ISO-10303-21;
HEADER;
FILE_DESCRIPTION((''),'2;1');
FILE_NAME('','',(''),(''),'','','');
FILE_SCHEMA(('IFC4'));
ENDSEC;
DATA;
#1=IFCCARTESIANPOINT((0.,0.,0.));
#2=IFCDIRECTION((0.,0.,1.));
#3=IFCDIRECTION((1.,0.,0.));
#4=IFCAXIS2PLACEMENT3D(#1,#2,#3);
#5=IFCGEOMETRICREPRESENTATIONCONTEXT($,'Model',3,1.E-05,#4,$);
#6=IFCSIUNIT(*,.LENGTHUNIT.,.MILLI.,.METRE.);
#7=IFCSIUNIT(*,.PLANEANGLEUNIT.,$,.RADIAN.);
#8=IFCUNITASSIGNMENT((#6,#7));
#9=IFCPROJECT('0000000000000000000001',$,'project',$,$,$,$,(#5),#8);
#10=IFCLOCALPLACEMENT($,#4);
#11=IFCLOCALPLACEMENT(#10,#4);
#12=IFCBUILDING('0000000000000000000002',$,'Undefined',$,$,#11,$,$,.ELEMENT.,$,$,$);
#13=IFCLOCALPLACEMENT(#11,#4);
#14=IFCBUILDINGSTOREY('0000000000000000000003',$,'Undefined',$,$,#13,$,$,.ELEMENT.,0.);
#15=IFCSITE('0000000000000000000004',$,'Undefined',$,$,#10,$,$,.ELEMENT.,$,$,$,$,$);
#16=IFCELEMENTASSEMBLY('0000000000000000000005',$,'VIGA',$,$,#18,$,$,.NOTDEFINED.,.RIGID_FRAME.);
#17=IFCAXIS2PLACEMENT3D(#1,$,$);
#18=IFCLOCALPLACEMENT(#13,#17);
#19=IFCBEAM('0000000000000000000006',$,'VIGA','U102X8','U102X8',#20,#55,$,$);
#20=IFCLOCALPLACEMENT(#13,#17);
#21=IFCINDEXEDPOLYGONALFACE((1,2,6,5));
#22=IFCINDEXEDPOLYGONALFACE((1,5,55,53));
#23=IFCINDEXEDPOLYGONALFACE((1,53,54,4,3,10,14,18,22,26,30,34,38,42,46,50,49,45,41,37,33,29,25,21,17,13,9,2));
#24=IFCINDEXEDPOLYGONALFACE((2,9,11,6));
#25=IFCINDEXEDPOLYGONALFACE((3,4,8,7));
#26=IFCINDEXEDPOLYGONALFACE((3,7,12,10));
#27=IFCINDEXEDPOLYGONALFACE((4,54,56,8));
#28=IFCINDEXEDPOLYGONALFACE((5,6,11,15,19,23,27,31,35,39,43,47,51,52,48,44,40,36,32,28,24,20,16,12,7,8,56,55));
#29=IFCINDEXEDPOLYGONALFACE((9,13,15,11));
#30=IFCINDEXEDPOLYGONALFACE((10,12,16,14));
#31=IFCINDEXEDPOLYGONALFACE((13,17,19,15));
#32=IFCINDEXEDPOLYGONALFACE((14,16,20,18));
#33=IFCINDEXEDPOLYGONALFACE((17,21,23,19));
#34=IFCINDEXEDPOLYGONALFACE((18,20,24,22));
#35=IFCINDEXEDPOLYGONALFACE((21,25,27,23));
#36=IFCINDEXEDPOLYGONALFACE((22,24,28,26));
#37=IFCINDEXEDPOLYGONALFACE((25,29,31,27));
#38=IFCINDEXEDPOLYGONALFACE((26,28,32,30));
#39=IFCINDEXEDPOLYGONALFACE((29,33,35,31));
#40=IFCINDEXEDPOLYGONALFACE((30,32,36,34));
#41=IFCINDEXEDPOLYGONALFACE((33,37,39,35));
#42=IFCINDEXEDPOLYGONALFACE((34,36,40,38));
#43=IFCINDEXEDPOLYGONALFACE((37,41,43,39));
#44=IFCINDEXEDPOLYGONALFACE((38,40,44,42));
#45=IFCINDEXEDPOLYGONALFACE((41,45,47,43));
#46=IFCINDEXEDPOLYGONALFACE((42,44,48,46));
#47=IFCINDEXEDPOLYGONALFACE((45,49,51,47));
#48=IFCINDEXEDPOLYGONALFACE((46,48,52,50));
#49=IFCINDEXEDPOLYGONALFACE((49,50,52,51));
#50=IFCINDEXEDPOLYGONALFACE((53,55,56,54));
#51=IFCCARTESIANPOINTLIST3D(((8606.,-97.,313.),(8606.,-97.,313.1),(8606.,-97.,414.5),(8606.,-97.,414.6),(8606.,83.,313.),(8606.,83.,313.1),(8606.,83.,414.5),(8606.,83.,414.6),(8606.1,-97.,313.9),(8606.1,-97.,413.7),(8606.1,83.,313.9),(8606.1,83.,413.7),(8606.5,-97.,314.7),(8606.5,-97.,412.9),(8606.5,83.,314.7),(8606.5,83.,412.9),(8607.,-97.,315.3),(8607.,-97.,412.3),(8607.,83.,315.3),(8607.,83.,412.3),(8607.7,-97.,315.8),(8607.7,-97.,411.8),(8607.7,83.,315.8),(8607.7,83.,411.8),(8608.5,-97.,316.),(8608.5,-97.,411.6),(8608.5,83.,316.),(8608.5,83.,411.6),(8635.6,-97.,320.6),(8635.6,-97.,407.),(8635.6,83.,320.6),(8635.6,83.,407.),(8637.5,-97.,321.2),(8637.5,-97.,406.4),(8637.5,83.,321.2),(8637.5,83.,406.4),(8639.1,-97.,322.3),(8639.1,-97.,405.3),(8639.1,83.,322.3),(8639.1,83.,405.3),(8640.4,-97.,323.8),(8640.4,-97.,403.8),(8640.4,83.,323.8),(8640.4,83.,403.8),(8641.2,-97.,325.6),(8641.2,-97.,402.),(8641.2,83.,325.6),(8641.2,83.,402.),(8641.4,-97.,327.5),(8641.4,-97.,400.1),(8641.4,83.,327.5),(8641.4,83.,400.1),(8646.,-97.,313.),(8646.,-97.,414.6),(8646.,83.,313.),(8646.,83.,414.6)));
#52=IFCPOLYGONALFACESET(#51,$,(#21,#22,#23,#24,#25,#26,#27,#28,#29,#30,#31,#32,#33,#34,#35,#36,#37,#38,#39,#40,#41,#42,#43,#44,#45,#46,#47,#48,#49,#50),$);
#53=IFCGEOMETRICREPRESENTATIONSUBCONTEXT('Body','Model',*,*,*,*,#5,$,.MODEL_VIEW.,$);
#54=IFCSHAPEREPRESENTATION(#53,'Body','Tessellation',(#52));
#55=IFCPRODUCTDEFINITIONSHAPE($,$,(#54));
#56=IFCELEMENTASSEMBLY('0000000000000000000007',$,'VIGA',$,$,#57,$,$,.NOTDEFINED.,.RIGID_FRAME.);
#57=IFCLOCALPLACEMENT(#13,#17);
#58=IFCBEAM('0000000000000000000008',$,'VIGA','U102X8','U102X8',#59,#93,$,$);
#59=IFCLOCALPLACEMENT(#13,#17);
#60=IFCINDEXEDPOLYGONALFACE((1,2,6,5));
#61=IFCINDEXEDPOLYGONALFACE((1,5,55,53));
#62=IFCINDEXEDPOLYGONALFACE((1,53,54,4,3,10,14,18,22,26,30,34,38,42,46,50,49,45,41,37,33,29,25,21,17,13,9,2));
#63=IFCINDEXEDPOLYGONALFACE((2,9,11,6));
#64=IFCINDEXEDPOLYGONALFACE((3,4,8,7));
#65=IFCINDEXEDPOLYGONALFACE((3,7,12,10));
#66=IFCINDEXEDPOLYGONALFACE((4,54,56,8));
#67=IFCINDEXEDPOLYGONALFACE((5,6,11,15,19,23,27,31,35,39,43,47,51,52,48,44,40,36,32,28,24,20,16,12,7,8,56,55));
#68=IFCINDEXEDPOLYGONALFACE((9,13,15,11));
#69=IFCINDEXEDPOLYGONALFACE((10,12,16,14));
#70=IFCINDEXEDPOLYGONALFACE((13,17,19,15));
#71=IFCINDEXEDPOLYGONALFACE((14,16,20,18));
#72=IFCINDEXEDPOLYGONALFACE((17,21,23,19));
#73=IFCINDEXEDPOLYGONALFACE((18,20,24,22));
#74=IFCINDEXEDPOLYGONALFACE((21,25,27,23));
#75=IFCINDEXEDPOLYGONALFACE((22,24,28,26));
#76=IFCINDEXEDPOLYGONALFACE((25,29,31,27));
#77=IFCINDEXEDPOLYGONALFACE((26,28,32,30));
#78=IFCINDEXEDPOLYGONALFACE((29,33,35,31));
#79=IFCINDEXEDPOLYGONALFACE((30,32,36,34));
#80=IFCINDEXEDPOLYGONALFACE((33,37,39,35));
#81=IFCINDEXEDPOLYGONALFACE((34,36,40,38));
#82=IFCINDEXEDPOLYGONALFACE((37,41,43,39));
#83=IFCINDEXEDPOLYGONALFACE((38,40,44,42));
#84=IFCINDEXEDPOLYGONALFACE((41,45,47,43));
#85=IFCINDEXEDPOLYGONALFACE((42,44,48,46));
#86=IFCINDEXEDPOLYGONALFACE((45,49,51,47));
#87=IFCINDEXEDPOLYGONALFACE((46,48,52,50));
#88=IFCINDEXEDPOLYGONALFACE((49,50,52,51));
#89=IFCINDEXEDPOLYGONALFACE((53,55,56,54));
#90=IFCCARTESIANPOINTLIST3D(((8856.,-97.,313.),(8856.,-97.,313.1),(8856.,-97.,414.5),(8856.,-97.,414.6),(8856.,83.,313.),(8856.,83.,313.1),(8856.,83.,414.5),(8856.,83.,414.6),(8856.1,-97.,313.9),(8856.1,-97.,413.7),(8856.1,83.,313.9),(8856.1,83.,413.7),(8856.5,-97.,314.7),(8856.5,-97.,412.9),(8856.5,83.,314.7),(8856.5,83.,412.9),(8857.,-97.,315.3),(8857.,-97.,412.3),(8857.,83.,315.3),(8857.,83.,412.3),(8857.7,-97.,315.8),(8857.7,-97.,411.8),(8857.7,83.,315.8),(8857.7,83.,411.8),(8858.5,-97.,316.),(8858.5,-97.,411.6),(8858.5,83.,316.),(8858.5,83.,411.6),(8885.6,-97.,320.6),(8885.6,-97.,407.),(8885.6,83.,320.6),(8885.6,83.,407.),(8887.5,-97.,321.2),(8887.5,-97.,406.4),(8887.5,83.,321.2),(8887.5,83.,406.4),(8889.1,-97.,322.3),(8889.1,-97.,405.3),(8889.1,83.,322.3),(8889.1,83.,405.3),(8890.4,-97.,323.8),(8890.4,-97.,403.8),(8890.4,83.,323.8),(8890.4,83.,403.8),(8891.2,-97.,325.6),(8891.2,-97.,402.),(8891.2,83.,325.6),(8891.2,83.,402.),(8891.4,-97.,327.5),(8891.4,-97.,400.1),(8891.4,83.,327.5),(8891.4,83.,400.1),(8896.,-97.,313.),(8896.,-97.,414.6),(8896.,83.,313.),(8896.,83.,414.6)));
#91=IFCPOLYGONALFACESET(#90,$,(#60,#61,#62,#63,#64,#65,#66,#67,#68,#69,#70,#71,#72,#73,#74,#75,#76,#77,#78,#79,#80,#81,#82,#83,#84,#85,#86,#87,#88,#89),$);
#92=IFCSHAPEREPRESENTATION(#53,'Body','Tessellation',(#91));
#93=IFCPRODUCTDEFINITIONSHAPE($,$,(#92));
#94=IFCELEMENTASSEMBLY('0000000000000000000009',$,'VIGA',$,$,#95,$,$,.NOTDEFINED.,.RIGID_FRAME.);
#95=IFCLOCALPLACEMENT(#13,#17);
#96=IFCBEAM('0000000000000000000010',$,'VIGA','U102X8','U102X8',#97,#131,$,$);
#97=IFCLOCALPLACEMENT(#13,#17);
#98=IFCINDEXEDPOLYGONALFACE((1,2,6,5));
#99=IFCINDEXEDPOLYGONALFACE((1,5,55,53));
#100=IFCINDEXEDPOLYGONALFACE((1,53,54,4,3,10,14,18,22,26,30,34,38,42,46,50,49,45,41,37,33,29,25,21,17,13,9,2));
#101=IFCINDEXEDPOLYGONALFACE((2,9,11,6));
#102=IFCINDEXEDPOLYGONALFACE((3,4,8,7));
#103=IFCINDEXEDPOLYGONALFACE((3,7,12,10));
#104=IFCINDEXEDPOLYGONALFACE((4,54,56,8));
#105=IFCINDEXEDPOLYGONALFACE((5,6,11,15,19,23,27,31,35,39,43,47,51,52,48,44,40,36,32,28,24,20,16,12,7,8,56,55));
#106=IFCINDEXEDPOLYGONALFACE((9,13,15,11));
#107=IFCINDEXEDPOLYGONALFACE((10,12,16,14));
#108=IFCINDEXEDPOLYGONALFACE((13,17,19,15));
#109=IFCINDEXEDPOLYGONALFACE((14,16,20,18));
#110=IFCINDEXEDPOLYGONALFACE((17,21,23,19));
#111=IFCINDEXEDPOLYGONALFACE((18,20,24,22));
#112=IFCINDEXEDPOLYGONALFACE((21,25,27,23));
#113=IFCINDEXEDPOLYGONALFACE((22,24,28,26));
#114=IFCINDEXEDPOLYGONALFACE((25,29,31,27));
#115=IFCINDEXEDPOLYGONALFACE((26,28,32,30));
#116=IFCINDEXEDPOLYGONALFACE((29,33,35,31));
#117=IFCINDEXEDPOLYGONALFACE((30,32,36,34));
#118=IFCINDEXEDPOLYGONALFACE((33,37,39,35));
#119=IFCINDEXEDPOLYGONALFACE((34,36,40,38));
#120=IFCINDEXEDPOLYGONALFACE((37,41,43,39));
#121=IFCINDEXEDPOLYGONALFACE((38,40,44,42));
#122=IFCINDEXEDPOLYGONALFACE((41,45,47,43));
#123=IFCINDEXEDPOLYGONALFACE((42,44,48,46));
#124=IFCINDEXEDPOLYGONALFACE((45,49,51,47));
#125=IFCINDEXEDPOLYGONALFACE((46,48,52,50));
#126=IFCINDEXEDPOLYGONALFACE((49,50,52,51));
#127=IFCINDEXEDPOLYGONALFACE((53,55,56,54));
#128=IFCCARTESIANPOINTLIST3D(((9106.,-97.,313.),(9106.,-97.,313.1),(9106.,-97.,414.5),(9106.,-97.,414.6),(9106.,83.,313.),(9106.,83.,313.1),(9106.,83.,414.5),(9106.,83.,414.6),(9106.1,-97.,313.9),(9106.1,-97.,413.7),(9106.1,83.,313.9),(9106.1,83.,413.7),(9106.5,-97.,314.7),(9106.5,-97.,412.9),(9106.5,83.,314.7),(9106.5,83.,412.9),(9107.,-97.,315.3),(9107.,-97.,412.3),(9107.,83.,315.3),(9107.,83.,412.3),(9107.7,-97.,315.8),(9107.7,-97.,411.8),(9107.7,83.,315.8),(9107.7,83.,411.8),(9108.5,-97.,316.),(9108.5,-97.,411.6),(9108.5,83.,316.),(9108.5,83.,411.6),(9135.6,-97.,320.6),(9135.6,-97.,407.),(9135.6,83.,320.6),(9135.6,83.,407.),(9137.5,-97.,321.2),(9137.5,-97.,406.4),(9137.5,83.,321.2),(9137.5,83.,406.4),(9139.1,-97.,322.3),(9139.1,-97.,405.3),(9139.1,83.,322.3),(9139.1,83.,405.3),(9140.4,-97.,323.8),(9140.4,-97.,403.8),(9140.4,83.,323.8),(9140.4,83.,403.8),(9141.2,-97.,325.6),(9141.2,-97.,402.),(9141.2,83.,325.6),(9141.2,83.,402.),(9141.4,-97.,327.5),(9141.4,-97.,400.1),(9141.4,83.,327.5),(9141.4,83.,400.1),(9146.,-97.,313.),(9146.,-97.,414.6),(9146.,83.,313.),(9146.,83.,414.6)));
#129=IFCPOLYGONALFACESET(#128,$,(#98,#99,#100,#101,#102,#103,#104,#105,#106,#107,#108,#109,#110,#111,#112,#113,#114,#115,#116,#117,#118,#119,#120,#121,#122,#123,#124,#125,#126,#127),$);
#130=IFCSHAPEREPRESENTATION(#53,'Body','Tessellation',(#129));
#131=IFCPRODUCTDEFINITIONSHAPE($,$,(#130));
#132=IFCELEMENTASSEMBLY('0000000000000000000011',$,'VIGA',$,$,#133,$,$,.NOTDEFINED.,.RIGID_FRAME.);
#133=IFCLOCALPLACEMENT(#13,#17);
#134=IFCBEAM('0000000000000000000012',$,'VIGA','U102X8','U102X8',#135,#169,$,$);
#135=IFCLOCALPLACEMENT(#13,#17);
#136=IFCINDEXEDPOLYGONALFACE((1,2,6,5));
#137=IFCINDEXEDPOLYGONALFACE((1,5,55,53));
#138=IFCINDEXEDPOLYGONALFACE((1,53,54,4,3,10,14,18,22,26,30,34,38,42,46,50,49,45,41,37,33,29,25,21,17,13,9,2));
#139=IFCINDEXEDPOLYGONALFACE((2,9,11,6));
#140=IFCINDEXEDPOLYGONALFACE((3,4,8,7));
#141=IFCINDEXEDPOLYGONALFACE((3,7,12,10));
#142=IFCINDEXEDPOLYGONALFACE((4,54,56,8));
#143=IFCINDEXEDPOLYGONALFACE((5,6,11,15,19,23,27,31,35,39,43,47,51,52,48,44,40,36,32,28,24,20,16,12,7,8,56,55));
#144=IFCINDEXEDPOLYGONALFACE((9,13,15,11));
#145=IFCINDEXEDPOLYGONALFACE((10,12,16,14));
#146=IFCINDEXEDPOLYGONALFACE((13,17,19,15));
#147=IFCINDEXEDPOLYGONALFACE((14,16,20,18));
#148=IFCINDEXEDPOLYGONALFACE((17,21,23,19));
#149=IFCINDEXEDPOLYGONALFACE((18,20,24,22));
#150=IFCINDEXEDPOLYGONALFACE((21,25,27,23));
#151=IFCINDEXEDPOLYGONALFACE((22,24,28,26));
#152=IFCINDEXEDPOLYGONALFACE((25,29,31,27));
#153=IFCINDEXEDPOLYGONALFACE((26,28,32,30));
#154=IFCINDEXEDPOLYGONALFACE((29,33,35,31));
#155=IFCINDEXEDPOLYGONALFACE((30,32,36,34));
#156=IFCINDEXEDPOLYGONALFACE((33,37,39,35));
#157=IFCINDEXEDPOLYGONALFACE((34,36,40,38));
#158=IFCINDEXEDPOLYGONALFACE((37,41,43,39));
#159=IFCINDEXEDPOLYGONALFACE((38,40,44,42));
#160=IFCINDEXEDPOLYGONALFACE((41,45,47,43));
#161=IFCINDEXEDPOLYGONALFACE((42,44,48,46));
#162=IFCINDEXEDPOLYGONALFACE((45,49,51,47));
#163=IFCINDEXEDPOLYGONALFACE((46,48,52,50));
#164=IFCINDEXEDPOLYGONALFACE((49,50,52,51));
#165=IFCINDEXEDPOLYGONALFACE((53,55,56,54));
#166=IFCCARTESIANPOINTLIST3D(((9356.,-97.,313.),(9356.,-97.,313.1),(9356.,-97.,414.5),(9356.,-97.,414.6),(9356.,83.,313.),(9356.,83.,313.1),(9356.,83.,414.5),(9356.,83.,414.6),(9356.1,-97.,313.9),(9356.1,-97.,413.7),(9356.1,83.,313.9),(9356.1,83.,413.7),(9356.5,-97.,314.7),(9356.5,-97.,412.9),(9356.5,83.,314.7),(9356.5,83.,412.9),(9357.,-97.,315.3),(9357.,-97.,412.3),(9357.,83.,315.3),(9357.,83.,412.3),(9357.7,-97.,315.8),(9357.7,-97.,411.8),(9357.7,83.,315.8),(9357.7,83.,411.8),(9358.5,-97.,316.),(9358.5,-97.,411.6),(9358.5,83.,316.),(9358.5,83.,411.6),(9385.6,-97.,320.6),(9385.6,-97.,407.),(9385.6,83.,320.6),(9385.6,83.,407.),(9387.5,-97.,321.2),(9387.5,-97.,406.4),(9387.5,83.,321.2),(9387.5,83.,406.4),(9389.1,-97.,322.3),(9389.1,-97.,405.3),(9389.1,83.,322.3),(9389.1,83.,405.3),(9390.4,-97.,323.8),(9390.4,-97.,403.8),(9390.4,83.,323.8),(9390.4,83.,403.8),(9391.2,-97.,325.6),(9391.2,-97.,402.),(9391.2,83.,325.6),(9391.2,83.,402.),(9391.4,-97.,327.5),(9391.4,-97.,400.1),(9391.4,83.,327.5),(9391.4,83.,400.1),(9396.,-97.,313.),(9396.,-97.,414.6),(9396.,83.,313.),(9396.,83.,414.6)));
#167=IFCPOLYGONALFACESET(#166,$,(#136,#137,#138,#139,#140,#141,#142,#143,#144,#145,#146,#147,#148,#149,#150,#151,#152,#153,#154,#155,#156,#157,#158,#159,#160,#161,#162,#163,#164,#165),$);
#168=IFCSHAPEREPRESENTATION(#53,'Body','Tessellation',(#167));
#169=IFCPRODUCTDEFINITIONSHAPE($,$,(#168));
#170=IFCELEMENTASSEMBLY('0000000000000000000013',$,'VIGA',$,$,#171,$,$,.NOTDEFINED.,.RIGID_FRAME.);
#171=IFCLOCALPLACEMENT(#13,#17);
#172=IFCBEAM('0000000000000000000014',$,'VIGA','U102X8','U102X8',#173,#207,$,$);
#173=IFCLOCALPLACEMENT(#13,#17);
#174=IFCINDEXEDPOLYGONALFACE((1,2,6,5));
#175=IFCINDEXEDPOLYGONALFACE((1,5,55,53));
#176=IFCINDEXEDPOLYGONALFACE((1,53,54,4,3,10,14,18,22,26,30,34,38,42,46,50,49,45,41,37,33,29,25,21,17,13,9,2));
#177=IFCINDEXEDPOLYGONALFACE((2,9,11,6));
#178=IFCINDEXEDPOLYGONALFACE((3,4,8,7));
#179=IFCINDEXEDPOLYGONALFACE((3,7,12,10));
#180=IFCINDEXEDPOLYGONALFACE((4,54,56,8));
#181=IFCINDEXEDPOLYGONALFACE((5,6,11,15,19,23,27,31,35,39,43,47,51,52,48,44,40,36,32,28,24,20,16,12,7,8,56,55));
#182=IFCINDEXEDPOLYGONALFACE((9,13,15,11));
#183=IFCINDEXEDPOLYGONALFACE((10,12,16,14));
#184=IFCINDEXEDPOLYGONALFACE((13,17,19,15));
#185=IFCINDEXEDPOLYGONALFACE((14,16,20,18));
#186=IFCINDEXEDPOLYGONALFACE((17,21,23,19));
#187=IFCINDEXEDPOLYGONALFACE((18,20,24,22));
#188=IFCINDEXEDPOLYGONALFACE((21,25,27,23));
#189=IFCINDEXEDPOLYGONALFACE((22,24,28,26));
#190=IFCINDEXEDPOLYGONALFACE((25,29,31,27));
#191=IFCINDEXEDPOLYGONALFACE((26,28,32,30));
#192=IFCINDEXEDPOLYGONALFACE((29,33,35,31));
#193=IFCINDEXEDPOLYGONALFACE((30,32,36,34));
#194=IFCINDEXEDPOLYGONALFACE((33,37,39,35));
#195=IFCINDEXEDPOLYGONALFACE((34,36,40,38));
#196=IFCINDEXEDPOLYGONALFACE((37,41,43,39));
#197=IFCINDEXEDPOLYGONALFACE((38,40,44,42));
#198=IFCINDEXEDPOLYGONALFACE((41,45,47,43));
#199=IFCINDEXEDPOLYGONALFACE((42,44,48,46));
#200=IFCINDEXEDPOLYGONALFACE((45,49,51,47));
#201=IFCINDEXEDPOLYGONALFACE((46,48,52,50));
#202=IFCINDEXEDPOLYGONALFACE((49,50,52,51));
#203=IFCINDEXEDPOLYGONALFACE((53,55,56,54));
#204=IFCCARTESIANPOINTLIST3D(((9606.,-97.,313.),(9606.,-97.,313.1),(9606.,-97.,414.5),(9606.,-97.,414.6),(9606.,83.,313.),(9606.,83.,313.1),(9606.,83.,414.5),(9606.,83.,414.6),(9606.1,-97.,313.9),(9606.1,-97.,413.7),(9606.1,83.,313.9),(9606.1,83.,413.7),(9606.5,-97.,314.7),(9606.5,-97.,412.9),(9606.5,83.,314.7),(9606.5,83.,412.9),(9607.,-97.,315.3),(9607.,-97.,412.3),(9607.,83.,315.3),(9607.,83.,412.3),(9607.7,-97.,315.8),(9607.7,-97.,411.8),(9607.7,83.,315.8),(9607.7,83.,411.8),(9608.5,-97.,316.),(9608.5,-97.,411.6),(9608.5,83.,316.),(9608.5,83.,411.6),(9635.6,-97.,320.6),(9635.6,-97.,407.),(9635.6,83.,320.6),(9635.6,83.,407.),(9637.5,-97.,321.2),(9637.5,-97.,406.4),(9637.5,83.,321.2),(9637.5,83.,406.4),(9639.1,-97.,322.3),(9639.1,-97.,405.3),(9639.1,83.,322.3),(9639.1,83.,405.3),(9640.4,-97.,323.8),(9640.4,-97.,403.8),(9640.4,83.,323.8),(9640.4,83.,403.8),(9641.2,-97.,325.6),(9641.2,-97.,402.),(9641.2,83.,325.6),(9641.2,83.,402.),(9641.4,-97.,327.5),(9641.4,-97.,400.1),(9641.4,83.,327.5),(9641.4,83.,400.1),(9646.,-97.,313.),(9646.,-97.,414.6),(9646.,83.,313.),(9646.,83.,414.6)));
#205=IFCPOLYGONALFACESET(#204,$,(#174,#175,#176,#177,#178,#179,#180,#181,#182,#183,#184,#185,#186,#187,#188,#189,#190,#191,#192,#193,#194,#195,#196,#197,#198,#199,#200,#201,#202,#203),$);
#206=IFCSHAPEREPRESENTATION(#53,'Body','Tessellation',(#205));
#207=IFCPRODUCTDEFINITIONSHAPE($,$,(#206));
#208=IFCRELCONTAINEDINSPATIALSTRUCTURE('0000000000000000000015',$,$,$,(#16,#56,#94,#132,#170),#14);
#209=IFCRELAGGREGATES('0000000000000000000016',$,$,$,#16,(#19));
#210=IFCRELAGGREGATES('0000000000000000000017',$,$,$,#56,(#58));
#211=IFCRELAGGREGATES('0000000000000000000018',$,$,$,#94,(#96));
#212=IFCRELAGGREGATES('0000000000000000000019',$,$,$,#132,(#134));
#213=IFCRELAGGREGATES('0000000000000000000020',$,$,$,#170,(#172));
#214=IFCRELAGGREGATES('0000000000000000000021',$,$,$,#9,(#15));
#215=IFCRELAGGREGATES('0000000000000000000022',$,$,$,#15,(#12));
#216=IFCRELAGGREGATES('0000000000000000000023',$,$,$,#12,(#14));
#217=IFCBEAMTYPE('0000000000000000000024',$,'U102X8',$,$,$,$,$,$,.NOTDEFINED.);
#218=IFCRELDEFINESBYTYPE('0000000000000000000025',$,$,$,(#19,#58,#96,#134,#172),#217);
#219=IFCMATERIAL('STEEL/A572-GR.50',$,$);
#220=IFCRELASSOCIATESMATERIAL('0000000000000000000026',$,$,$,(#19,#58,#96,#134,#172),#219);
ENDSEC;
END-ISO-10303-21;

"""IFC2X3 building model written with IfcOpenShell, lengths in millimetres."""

from ifc_helpers import new_model, si_unit, frame, origin_with_axes, origin_2d_with_axis, place, context, subcontext, project, spatial, u_section, extrude, material, type_object, element, aggregate, save


model = new_model("IFC2X3")

# Units and contexts
model_context = context("Model", 3, precision=1e-05, world=origin_with_axes())
body_context = subcontext(model_context, "Body", "Model", "MODEL_VIEW")
ifc_project = project(units=[si_unit("LENGTHUNIT", "METRE", prefix="MILLI"), si_unit("PLANEANGLEUNIT", "RADIAN")], contexts=[model_context])

# Site, building, storey
site_placement = place(None, origin_with_axes())
site = spatial("IfcSite", under=ifc_project, at=site_placement, Name="Undefined", CompositionType="ELEMENT")
building_placement = place(site_placement, origin_with_axes())
building = spatial("IfcBuilding", under=site, at=building_placement, Name="Undefined", CompositionType="ELEMENT")
storey_placement = place(building_placement, origin_with_axes())
storey = spatial("IfcBuildingStorey", under=building, at=storey_placement, Name="Undefined", CompositionType="ELEMENT", Elevation=0.0)

# Element assemblies, beams
ifc_material_1 = material(Name="STEEL/A572-GR.50")
beam_type = type_object("IfcBeamType", Name="U102X8", PredefinedType="NOTDEFINED")
assembly_1_placement = place(storey_placement, origin_with_axes())
assembly_1 = element("IfcElementAssembly", 1, at=assembly_1_placement, inside=storey, Name="VIGA", AssemblyPlace="NOTDEFINED", PredefinedType="RIGID_FRAME")
beam_1_placement = place(assembly_1_placement, frame((8626.0, 83.0, 363.8), z_axis=(0.0, 0.0, 1.0), x_axis=(0.0, -1.0, 0.0)))
beam_1 = element("IfcBeam", 2, at=beam_1_placement, type_object=beam_type, material=ifc_material_1, Name="VIGA", Description="U102X8", ObjectType="U102X8", context=body_context, shape_type="SweptSolid", body=[
    extrude(u_section(Depth=101.6, FlangeWidth=40.0, WebThickness=4.6, FlangeThickness=6.0, FilletRadius=7.0, EdgeRadius=3.0, FlangeSlope=0.16839, at=origin_2d_with_axis()), frame((180.0, 0.0, 0.0), z_axis=(-1.0, 0.0, 0.0), x_axis=(0.0, -1.0, 0.0)), (0.0, 0.0, 1.0), 180.0),
])
aggregate(assembly_1, [beam_1])
assembly_2_placement = place(storey_placement, origin_with_axes())
assembly_2 = element("IfcElementAssembly", 3, at=assembly_2_placement, inside=storey, Name="VIGA", AssemblyPlace="NOTDEFINED", PredefinedType="RIGID_FRAME")
beam_2_placement = place(assembly_2_placement, frame((8876.0, 83.0, 363.8), z_axis=(0.0, 0.0, 1.0), x_axis=(0.0, -1.0, 0.0)))
beam_2 = element("IfcBeam", 4, at=beam_2_placement, type_object=beam_type, material=ifc_material_1, Name="VIGA", Description="U102X8", ObjectType="U102X8", context=body_context, shape_type="SweptSolid", body=[
    extrude(u_section(Depth=101.6, FlangeWidth=40.0, WebThickness=4.6, FlangeThickness=6.0, FilletRadius=7.0, EdgeRadius=3.0, FlangeSlope=0.16839, at=origin_2d_with_axis()), frame((180.0, 0.0, 0.0), z_axis=(-1.0, 0.0, 0.0), x_axis=(0.0, -1.0, 0.0)), (0.0, 0.0, 1.0), 180.0),
])
aggregate(assembly_2, [beam_2])
assembly_3_placement = place(storey_placement, origin_with_axes())
assembly_3 = element("IfcElementAssembly", 5, at=assembly_3_placement, inside=storey, Name="VIGA", AssemblyPlace="NOTDEFINED", PredefinedType="RIGID_FRAME")
beam_3_placement = place(assembly_3_placement, frame((9126.0, 83.0, 363.8), z_axis=(0.0, 0.0, 1.0), x_axis=(0.0, -1.0, 0.0)))
beam_3 = element("IfcBeam", 6, at=beam_3_placement, type_object=beam_type, material=ifc_material_1, Name="VIGA", Description="U102X8", ObjectType="U102X8", context=body_context, shape_type="SweptSolid", body=[
    extrude(u_section(Depth=101.6, FlangeWidth=40.0, WebThickness=4.6, FlangeThickness=6.0, FilletRadius=7.0, EdgeRadius=3.0, FlangeSlope=0.16839, at=origin_2d_with_axis()), frame((180.0, 0.0, 0.0), z_axis=(-1.0, 0.0, 0.0), x_axis=(0.0, -1.0, 0.0)), (0.0, 0.0, 1.0), 180.0),
])
aggregate(assembly_3, [beam_3])
assembly_4_placement = place(storey_placement, origin_with_axes())
assembly_4 = element("IfcElementAssembly", 7, at=assembly_4_placement, inside=storey, Name="VIGA", AssemblyPlace="NOTDEFINED", PredefinedType="RIGID_FRAME")
beam_4_placement = place(assembly_4_placement, frame((9376.0, 83.0, 363.8), z_axis=(0.0, 0.0, 1.0), x_axis=(0.0, -1.0, 0.0)))
beam_4 = element("IfcBeam", 8, at=beam_4_placement, type_object=beam_type, material=ifc_material_1, Name="VIGA", Description="U102X8", ObjectType="U102X8", context=body_context, shape_type="SweptSolid", body=[
    extrude(u_section(Depth=101.6, FlangeWidth=40.0, WebThickness=4.6, FlangeThickness=6.0, FilletRadius=7.0, EdgeRadius=3.0, FlangeSlope=0.16839, at=origin_2d_with_axis()), frame((180.0, 0.0, 0.0), z_axis=(-1.0, 0.0, 0.0), x_axis=(0.0, -1.0, 0.0)), (0.0, 0.0, 1.0), 180.0),
])
aggregate(assembly_4, [beam_4])
assembly_5_placement = place(storey_placement, origin_with_axes())
assembly_5 = element("IfcElementAssembly", 9, at=assembly_5_placement, inside=storey, Name="VIGA", AssemblyPlace="NOTDEFINED", PredefinedType="RIGID_FRAME")
beam_5_placement = place(assembly_5_placement, frame((9626.0, 83.0, 363.8), z_axis=(0.0, 0.0, 1.0), x_axis=(0.0, -1.0, 0.0)))
beam_5 = element("IfcBeam", 10, at=beam_5_placement, type_object=beam_type, material=ifc_material_1, Name="VIGA", Description="U102X8", ObjectType="U102X8", context=body_context, shape_type="SweptSolid", body=[
    extrude(u_section(Depth=101.6, FlangeWidth=40.0, WebThickness=4.6, FlangeThickness=6.0, FilletRadius=7.0, EdgeRadius=3.0, FlangeSlope=0.16839, at=origin_2d_with_axis()), frame((180.0, 0.0, 0.0), z_axis=(-1.0, 0.0, 0.0), x_axis=(0.0, -1.0, 0.0)), (0.0, 0.0, 1.0), 180.0),
])
aggregate(assembly_5, [beam_5])

save(model, "model.ifc")
